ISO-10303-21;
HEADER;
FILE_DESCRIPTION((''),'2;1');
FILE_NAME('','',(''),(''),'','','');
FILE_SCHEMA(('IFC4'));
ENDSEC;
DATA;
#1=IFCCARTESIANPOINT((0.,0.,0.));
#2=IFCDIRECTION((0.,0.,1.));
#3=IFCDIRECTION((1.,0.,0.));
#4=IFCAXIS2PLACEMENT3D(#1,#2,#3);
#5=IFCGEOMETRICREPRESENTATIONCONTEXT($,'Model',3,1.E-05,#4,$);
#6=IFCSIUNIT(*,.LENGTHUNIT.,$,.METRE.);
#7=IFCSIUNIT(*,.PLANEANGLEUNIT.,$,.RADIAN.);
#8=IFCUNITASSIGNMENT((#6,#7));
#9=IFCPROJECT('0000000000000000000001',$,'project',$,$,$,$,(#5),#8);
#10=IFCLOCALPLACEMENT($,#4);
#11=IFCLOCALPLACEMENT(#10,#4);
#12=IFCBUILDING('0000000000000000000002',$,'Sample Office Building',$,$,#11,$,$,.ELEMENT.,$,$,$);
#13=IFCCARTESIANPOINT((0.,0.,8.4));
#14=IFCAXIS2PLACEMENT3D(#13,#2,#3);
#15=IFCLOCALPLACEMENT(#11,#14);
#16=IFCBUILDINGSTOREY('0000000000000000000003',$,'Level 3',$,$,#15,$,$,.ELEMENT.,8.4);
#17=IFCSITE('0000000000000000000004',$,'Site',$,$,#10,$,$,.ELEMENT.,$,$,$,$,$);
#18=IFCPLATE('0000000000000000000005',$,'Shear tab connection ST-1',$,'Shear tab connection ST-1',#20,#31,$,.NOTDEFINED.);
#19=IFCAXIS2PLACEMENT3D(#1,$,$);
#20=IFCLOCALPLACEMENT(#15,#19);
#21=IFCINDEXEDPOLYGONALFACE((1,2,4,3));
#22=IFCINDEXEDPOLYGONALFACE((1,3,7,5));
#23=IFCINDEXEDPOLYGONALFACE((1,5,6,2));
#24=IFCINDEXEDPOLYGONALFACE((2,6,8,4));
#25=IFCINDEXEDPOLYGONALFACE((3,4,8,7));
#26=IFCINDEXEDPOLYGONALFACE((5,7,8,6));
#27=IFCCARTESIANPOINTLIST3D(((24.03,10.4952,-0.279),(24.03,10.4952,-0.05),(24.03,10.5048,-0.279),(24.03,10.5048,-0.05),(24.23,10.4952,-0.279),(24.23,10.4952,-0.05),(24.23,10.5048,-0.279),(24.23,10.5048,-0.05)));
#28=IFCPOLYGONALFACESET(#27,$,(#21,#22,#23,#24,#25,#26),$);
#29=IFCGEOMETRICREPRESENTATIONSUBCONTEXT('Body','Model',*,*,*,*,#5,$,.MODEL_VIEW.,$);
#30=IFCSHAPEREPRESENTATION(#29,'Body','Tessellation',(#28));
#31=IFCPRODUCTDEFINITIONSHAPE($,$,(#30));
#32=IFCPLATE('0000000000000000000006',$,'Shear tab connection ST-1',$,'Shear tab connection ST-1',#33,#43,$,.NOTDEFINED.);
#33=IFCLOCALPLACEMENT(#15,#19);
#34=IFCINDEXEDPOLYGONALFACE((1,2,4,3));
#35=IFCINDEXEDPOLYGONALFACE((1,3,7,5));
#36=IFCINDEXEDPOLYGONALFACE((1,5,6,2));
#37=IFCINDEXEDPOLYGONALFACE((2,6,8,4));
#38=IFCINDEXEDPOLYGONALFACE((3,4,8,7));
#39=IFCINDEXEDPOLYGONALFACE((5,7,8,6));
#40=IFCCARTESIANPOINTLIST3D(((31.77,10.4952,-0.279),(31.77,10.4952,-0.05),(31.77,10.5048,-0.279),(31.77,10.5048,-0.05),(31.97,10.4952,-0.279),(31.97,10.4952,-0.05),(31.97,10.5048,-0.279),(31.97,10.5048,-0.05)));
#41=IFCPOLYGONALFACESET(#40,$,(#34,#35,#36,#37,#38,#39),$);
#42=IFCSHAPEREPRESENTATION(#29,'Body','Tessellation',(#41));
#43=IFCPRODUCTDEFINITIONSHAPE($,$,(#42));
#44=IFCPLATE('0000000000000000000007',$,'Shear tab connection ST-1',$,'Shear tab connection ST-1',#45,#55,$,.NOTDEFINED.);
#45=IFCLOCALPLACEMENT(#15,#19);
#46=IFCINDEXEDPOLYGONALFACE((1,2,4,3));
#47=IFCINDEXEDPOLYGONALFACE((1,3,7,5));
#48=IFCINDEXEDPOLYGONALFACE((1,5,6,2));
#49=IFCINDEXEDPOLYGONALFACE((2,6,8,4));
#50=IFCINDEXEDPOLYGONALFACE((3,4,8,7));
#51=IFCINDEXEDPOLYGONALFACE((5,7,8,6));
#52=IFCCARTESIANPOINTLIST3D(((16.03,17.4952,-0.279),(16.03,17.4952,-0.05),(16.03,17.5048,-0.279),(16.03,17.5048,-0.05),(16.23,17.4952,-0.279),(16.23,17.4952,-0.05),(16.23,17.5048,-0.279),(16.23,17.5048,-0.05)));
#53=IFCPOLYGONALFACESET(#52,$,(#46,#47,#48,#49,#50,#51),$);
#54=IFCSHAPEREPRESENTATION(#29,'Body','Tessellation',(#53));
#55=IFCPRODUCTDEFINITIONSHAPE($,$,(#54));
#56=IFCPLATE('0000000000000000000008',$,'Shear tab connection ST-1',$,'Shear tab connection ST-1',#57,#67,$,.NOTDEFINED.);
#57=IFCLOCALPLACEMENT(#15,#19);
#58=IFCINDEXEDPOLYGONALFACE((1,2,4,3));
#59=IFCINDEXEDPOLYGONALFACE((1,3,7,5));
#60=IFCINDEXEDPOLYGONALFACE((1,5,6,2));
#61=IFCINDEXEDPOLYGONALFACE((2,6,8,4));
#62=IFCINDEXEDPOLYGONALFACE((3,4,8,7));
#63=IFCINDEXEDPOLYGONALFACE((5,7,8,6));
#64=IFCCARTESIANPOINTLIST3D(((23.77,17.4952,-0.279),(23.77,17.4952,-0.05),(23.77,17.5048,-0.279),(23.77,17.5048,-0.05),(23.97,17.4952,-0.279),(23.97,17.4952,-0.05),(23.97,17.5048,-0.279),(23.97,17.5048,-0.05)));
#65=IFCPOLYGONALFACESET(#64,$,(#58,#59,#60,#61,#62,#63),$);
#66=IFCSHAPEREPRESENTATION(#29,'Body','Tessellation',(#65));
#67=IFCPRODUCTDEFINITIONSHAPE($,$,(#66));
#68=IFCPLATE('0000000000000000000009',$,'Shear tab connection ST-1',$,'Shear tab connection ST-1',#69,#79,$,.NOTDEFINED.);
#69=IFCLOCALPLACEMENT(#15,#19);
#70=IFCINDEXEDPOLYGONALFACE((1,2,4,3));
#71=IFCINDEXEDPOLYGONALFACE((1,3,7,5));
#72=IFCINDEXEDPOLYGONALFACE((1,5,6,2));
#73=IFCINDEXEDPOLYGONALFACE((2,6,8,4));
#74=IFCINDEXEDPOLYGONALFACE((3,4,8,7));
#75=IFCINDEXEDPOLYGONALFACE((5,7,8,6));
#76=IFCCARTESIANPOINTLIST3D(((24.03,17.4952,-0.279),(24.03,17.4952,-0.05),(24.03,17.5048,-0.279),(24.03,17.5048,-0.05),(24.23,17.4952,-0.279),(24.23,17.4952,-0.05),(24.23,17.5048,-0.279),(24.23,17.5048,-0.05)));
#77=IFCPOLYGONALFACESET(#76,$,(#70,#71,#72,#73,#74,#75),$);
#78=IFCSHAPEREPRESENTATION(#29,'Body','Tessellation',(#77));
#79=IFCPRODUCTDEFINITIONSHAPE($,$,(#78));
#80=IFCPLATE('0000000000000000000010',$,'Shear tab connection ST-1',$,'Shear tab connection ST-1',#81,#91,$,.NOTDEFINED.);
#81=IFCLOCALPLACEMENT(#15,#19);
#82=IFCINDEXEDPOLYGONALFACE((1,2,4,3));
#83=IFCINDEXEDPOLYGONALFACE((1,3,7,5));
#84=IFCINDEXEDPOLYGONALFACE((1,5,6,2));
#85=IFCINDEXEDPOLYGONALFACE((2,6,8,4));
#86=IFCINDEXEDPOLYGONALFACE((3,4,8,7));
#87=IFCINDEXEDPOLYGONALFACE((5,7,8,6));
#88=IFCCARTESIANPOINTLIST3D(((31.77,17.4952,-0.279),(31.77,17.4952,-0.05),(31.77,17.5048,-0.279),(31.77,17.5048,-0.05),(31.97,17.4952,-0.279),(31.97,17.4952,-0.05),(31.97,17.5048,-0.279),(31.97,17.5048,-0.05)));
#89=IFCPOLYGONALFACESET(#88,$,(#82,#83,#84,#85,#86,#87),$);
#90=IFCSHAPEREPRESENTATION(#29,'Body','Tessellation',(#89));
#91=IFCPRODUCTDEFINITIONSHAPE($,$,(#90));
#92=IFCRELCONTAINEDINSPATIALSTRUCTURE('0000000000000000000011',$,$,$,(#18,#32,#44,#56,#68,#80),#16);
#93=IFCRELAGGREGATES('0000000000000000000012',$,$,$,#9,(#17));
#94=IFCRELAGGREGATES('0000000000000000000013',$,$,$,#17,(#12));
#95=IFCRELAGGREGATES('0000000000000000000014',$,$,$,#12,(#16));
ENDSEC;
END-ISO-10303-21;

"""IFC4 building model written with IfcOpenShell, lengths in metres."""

from ifc_helpers import new_model, si_unit, frame, origin_with_axes, place, context, subcontext, project, spatial, rectangle, extrude, element, save


model = new_model("IFC4")

# Units and contexts
model_context = context("Model", 3, precision=1e-05, world=origin_with_axes())
body_context = subcontext(model_context, "Body", "Model", "MODEL_VIEW")
ifc_project = project(units=[si_unit("LENGTHUNIT", "METRE"), si_unit("PLANEANGLEUNIT", "RADIAN")], contexts=[model_context])

# Site, building, storey
site_placement = place(None, origin_with_axes())
site = spatial("IfcSite", under=ifc_project, at=site_placement, Name="Site", CompositionType="ELEMENT")
building_placement = place(site_placement, origin_with_axes())
building = spatial("IfcBuilding", under=site, at=building_placement, Name="Sample Office Building", CompositionType="ELEMENT")
storey_placement = place(building_placement, frame((0.0, 0.0, 8.4), z_axis=(0.0, 0.0, 1.0), x_axis=(1.0, 0.0, 0.0)))
storey = spatial("IfcBuildingStorey", under=building, at=storey_placement, Name="Level 3", CompositionType="ELEMENT", Elevation=8.4)

# Plates
for number, where, z_axis, x_axis, name in (
    (1, (24.13, 10.5, 8.121), (0.0, 0.0, 1.0), (1.0, 0.0, 0.0), "Shear tab connection ST-1"),
    (2, (31.87, 10.5, 8.121), (0.0, 0.0, 1.0), (1.0, 0.0, 0.0), "Shear tab connection ST-1"),
):
    element("IfcPlate", number, at=place(None, frame(where, z_axis=z_axis, x_axis=x_axis)), inside=storey, Name=name, ObjectType="Shear tab connection ST-1", PredefinedType="NOTDEFINED", context=body_context, shape_type="SweptSolid", body=[
        extrude(rectangle(XDim=0.2, YDim=0.0095), None, (0.0, 0.0, 1.0), 0.229),
    ])
for number, where, z_axis, x_axis, name in (
    (3, (16.13, 17.5, 8.121), (0.0, 0.0, 1.0), (1.0, 0.0, 0.0), "Shear tab connection ST-1"),
    (4, (23.87, 17.5, 8.121), (0.0, 0.0, 1.0), (1.0, 0.0, 0.0), "Shear tab connection ST-1"),
    (5, (24.13, 17.5, 8.121), (0.0, 0.0, 1.0), (1.0, 0.0, 0.0), "Shear tab connection ST-1"),
    (6, (31.87, 17.5, 8.121), (0.0, 0.0, 1.0), (1.0, 0.0, 0.0), "Shear tab connection ST-1"),
):
    element("IfcPlate", number, at=place(None, frame(where, z_axis=z_axis, x_axis=x_axis)), inside=storey, Name=name, ObjectType="Shear tab connection ST-1", PredefinedType="NOTDEFINED", context=body_context, shape_type="SweptSolid", body=[
        extrude(rectangle(XDim=0.2, YDim=0.0095), None, (0.0, 0.0, 1.0), 0.229),
    ])

save(model, "model.ifc")
